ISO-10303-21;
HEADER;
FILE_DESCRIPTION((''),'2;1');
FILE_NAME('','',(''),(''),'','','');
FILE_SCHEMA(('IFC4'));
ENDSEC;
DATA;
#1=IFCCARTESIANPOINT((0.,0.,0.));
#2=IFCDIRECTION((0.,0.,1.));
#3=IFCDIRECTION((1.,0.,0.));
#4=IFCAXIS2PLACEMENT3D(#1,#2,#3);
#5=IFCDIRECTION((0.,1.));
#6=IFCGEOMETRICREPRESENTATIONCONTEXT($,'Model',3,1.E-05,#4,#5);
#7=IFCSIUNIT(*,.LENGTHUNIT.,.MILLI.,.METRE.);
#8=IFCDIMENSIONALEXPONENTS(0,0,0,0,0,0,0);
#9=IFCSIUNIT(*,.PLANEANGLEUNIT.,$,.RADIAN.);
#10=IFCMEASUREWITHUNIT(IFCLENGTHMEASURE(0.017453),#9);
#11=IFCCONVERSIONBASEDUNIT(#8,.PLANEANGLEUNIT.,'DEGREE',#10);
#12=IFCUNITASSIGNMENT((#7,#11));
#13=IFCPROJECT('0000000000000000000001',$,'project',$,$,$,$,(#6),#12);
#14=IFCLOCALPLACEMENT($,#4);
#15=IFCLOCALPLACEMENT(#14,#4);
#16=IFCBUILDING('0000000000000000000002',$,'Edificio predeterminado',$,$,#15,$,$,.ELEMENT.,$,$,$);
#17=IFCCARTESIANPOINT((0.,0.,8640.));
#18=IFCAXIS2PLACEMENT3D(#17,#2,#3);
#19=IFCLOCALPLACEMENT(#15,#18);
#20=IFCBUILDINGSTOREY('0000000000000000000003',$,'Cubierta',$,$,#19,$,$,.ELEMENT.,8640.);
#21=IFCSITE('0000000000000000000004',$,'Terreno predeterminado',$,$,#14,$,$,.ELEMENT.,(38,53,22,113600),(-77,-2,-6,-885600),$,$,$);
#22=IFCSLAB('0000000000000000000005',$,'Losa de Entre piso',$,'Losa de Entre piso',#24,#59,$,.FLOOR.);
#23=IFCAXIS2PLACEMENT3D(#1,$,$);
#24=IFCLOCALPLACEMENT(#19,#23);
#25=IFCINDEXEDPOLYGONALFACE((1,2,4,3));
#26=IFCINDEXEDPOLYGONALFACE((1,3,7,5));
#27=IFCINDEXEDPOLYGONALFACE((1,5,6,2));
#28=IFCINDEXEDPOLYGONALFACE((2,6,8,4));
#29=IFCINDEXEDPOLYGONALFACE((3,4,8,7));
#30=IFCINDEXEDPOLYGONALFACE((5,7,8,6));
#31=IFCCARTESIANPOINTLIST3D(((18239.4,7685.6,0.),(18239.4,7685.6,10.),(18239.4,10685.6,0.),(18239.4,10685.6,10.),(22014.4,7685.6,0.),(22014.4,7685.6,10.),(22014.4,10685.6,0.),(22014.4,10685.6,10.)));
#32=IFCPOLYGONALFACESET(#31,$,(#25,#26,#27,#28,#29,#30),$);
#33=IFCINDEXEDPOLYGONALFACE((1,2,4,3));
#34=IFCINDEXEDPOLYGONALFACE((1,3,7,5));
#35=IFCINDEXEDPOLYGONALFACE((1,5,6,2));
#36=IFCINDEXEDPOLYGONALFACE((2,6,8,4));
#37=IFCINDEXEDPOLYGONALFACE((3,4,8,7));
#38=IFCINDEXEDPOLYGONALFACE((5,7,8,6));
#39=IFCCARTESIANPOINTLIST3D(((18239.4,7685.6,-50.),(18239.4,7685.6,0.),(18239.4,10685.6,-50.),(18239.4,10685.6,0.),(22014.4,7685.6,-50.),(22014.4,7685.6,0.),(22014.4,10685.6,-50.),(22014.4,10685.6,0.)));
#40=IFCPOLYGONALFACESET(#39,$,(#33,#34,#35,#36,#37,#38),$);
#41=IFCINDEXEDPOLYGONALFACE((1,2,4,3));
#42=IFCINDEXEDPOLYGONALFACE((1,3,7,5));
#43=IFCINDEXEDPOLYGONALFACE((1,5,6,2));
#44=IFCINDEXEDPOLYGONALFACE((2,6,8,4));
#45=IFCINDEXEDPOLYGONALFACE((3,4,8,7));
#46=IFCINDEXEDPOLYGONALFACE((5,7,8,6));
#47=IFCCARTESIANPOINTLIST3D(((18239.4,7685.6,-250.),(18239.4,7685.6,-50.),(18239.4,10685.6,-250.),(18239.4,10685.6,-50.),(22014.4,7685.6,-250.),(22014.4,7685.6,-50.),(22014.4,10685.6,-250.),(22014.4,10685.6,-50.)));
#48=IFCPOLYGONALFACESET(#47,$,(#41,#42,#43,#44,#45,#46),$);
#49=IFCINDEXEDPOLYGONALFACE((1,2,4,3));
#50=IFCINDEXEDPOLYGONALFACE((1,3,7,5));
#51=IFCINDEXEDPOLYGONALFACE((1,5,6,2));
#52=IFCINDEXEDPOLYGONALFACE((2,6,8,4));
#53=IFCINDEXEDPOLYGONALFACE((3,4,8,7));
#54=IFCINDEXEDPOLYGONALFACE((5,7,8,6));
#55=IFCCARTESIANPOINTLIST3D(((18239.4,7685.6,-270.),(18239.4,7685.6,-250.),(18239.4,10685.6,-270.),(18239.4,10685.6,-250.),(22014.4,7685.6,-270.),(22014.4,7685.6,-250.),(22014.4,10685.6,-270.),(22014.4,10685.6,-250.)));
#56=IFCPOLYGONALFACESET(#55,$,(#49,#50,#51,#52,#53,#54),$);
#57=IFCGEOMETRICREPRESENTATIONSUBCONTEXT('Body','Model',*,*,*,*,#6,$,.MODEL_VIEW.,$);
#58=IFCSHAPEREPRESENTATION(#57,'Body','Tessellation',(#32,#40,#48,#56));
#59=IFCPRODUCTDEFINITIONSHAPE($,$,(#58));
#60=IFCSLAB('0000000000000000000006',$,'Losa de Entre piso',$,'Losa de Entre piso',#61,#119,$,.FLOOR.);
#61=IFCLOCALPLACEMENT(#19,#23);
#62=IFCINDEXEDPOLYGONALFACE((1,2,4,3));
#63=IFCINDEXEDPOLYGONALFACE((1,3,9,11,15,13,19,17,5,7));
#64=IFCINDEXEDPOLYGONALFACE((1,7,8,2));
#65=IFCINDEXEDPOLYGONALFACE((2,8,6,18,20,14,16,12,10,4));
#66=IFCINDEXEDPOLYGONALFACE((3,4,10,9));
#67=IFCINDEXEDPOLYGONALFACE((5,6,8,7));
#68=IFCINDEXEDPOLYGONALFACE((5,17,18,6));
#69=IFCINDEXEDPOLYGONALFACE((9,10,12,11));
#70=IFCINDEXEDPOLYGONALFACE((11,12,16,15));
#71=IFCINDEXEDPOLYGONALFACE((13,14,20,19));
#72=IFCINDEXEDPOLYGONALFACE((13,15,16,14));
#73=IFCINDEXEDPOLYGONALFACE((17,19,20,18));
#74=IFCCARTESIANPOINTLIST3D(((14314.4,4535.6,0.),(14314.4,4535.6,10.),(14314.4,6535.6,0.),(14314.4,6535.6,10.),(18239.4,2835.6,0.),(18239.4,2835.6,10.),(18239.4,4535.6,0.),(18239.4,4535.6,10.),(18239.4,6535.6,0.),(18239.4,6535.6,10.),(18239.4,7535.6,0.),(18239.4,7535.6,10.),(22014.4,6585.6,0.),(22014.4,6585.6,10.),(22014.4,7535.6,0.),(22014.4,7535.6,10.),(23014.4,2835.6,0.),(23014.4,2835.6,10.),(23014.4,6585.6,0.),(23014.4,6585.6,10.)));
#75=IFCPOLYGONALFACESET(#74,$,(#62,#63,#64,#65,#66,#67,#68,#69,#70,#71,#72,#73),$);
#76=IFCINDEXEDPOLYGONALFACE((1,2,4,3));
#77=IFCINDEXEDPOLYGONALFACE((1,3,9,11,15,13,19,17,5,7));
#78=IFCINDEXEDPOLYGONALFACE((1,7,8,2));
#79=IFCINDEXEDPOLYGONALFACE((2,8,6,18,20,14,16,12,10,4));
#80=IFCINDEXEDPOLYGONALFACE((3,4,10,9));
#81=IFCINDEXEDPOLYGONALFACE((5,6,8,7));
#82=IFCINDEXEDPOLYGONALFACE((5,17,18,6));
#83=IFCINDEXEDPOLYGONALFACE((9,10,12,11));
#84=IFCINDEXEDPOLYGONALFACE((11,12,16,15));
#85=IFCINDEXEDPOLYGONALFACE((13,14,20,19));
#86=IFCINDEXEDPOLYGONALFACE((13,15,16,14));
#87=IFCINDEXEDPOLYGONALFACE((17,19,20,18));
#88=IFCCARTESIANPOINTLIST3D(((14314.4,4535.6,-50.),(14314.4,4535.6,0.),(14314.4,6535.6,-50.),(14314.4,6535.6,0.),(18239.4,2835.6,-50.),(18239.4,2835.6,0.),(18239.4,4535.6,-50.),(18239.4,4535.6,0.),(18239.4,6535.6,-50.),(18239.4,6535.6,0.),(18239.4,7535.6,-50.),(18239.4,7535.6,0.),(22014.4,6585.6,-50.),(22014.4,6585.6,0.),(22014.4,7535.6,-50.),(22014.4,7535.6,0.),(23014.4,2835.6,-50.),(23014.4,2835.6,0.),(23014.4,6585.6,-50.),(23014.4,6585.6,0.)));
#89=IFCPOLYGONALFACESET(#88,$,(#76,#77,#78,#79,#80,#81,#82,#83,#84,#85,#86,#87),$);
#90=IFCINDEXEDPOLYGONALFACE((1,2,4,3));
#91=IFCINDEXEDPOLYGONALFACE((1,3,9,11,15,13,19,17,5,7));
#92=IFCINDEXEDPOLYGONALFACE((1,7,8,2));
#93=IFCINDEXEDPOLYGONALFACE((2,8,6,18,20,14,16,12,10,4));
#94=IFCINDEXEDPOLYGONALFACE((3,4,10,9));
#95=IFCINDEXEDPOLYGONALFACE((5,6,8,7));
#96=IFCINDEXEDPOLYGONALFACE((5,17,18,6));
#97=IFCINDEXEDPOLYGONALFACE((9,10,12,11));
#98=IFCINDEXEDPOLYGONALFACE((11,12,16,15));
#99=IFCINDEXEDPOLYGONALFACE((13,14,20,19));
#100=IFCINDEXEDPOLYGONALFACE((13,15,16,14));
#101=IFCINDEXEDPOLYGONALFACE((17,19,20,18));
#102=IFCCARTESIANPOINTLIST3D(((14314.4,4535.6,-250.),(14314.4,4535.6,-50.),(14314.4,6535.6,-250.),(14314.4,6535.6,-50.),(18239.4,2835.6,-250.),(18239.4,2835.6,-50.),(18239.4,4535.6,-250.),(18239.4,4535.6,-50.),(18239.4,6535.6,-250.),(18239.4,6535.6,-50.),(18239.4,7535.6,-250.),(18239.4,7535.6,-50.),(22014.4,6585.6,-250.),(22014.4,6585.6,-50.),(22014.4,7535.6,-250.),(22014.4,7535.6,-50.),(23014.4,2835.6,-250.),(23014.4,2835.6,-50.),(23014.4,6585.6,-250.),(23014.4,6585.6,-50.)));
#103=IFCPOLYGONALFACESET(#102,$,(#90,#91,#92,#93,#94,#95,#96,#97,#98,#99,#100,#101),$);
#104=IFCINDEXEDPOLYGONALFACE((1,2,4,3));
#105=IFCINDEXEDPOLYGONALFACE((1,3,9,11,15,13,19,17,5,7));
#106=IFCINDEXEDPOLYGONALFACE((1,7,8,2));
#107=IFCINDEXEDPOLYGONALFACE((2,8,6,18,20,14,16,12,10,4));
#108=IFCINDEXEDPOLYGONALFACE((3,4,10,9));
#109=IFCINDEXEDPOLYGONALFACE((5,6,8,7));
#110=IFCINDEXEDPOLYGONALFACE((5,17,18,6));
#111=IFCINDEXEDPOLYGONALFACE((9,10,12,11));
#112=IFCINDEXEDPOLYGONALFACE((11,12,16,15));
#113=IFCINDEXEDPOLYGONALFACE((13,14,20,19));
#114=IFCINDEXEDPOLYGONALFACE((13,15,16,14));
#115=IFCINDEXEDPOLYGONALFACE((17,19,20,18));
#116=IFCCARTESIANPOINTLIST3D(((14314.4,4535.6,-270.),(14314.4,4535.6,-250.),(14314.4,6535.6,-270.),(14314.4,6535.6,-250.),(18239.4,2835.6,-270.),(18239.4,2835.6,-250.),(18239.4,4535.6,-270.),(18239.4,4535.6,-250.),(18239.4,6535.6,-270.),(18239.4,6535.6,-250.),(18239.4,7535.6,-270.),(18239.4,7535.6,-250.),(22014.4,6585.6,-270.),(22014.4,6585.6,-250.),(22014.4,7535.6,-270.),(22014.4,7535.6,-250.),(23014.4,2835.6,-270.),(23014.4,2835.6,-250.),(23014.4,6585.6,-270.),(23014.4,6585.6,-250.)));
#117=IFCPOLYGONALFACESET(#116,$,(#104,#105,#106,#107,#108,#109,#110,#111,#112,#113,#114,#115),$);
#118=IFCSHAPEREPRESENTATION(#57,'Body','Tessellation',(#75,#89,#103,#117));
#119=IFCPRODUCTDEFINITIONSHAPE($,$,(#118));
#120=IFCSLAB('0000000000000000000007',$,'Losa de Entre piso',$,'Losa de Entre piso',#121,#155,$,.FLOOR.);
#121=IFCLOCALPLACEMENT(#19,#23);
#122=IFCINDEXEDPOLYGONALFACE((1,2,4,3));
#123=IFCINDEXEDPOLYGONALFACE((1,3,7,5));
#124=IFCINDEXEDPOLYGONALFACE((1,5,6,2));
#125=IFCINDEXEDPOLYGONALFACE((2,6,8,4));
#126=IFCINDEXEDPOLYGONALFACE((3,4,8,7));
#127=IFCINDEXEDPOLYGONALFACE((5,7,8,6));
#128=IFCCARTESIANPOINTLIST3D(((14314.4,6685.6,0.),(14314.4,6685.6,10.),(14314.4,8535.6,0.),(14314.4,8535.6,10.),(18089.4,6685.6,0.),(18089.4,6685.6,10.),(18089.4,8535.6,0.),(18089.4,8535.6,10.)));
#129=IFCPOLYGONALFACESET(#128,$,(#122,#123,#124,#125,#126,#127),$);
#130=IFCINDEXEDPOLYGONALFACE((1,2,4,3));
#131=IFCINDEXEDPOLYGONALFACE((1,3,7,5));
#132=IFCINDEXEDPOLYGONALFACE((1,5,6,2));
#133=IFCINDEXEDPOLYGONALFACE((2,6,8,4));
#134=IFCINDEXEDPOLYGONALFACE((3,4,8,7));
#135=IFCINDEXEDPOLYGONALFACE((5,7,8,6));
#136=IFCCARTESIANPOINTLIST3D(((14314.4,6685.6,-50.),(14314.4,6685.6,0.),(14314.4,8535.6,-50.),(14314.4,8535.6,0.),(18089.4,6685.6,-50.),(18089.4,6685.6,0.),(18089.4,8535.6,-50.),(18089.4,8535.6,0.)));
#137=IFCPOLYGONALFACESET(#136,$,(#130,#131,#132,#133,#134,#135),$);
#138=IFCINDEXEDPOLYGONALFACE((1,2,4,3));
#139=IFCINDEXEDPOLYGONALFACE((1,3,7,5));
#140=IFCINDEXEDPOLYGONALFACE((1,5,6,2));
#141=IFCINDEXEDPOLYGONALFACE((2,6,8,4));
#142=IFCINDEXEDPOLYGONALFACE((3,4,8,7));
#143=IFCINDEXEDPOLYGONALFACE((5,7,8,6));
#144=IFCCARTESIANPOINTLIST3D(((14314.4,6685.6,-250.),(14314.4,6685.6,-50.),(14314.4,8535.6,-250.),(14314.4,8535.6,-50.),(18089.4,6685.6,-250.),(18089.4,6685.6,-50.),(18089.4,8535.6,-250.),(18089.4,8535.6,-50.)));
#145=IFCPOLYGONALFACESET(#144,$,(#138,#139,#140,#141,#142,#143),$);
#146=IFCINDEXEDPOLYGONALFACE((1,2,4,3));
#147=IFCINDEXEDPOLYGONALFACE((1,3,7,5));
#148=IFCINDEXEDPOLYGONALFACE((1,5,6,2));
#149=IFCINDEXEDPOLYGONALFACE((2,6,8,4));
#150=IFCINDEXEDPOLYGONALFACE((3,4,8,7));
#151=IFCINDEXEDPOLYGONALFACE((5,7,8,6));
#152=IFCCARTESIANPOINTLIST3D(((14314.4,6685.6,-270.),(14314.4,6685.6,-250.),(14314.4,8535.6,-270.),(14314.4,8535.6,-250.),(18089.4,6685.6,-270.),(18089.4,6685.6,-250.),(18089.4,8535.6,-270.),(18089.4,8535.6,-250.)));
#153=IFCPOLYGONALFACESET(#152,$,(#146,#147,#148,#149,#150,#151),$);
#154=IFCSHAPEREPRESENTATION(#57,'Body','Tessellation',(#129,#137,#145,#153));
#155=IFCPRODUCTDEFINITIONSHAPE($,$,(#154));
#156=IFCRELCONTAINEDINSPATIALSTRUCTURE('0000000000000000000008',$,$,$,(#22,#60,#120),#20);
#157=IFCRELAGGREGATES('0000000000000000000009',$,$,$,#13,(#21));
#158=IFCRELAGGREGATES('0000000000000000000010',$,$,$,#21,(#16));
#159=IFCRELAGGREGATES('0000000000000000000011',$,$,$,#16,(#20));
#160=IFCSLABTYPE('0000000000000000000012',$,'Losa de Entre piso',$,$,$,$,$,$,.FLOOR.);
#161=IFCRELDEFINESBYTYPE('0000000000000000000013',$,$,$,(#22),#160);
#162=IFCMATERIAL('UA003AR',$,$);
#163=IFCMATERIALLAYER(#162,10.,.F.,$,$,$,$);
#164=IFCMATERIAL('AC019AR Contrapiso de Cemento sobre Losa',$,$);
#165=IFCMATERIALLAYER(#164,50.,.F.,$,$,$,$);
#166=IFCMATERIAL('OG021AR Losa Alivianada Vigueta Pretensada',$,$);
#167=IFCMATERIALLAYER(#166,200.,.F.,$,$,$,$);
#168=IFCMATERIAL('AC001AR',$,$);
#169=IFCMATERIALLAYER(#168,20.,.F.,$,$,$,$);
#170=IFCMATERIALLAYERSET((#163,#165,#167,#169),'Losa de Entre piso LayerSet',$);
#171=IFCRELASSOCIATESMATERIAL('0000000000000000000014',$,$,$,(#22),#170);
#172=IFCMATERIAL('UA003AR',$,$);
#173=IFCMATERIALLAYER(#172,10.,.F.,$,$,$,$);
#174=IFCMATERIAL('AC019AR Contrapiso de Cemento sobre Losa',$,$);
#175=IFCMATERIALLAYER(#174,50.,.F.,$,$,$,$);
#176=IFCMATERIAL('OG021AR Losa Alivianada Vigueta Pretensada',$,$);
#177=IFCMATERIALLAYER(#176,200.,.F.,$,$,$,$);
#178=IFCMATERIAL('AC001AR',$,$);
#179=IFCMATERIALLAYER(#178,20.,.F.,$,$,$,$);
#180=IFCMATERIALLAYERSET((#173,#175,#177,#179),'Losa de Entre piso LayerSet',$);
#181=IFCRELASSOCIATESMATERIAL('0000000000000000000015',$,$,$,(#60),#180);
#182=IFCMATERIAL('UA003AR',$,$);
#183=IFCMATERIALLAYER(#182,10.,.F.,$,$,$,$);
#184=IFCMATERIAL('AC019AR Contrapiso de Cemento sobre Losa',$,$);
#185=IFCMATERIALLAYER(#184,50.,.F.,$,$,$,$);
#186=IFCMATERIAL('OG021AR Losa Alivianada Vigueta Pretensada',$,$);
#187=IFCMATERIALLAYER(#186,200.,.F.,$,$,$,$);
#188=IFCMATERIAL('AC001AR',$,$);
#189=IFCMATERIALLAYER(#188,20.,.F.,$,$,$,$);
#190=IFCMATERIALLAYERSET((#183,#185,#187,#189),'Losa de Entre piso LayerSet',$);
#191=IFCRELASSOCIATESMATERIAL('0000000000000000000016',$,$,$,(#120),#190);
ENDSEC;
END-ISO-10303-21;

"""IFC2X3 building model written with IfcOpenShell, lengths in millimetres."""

from ifc_helpers import new_model, entity, si_unit, converted_unit, direction, frame, origin_with_axes, place, context, subcontext, project, spatial, polyline, outline, extrude, material, layer, layer_set, layer_usage, type_object, element, save


model = new_model("IFC2X3")

# Units and contexts
model_context = context("Model", 3, precision=1e-05, world=origin_with_axes(), true_north=direction((0.0, 1.0)))
body_context = subcontext(model_context, "Body", "Model", "MODEL_VIEW")
ifc_project = project(units=[si_unit("LENGTHUNIT", "METRE", prefix="MILLI"), converted_unit("PLANEANGLEUNIT", "DEGREE", entity("IfcLengthMeasure", 0.017453), si_unit("PLANEANGLEUNIT", "RADIAN"), dimensions=[0, 0, 0, 0, 0, 0, 0])], contexts=[model_context])

# Site, building, storey
site_placement = place(None, origin_with_axes())
site = spatial("IfcSite", under=ifc_project, at=site_placement, Name="Terreno predeterminado", CompositionType="ELEMENT", RefLatitude=(38, 53, 22, 113600), RefLongitude=(-77, -2, -6, -885600))
building_placement = place(site_placement, origin_with_axes())
building = spatial("IfcBuilding", under=site, at=building_placement, Name="Edificio predeterminado", CompositionType="ELEMENT")
storey_placement = place(building_placement, frame((0.0, 0.0, 8640.0), z_axis=(0.0, 0.0, 1.0), x_axis=(1.0, 0.0, 0.0)))
storey = spatial("IfcBuildingStorey", under=building, at=storey_placement, Name="Cubierta", CompositionType="ELEMENT", Elevation=8640.0)

# Slabs
ifc_material_1 = material(Name="UA003AR")
ifc_layer_1 = layer(ifc_material_1, 10.0, ventilated=False)
ifc_material_2 = material(Name="AC019AR Contrapiso de Cemento sobre Losa")
ifc_layer_2 = layer(ifc_material_2, 50.0, ventilated=False)
ifc_material_3 = material(Name="OG021AR Losa Alivianada Vigueta Pretensada")
ifc_layer_3 = layer(ifc_material_3, 200.0, ventilated=False)
ifc_material_4 = material(Name="AC001AR")
ifc_layer_4 = layer(ifc_material_4, 20.0, ventilated=False)
ifc_layer_set_1 = layer_set([ifc_layer_1, ifc_layer_2, ifc_layer_3, ifc_layer_4], Name="Losa de Entre piso LayerSet")
ifc_layer_usage_1 = layer_usage(ifc_layer_set_1, "AXIS3", "NEGATIVE", 0.0)
slab_type = type_object("IfcSlabType", Name="Losa de Entre piso", PredefinedType="FLOOR")
slab_1_placement = place(storey_placement, frame((0.0, 0.0, -8640.0), z_axis=(0.0, 0.0, 1.0), x_axis=(1.0, 0.0, 0.0)))
element("IfcSlab", 1, at=slab_1_placement, inside=storey, type_object=slab_type, material=ifc_layer_usage_1, Name="Losa de Entre piso", ObjectType="Losa de Entre piso", PredefinedType="FLOOR", context=body_context, shape_type="SweptSolid", body=[
    extrude(outline(polyline([(0.0, 3000.0), (3775.0, 3000.0), (3775.0, 0.0), (0.0, 0.0), (0.0, 3000.0)])), frame((22014.4, 7685.6, 8640.0), z_axis=(0.0, 0.0, -1.0), x_axis=(-1.0, 0.0, 0.0)), (0.0, 0.0, -1.0), 10.0),
    extrude(outline(polyline([(0.0, 3000.0), (3775.0, 3000.0), (3775.0, 0.0), (0.0, 0.0), (0.0, 3000.0)])), frame((22014.4, 7685.6, 8590.0), z_axis=(0.0, 0.0, -1.0), x_axis=(-1.0, 0.0, 0.0)), (0.0, 0.0, -1.0), 50.0),
    extrude(outline(polyline([(0.0, 3000.0), (3775.0, 3000.0), (3775.0, 0.0), (0.0, 0.0), (0.0, 3000.0)])), frame((22014.4, 7685.6, 8390.0), z_axis=(0.0, 0.0, -1.0), x_axis=(-1.0, 0.0, 0.0)), (0.0, 0.0, -1.0), 200.0),
    extrude(outline(polyline([(0.0, 3000.0), (3775.0, 3000.0), (3775.0, 0.0), (0.0, 0.0), (0.0, 3000.0)])), frame((22014.4, 7685.6, 8370.0), z_axis=(0.0, 0.0, -1.0), x_axis=(-1.0, 0.0, 0.0)), (0.0, 0.0, -1.0), 20.0),
])
ifc_material_5 = material(Name="UA003AR")
ifc_layer_5 = layer(ifc_material_5, 10.0, ventilated=False)
ifc_material_6 = material(Name="AC019AR Contrapiso de Cemento sobre Losa")
ifc_layer_6 = layer(ifc_material_6, 50.0, ventilated=False)
ifc_material_7 = material(Name="OG021AR Losa Alivianada Vigueta Pretensada")
ifc_layer_7 = layer(ifc_material_7, 200.0, ventilated=False)
ifc_material_8 = material(Name="AC001AR")
ifc_layer_8 = layer(ifc_material_8, 20.0, ventilated=False)
ifc_layer_set_2 = layer_set([ifc_layer_5, ifc_layer_6, ifc_layer_7, ifc_layer_8], Name="Losa de Entre piso LayerSet")
ifc_layer_usage_2 = layer_usage(ifc_layer_set_2, "AXIS3", "NEGATIVE", 0.0)
slab_2_placement = place(storey_placement, frame((0.0, 0.0, -8640.0), z_axis=(0.0, 0.0, 1.0), x_axis=(1.0, 0.0, 0.0)))
element("IfcSlab", 2, at=slab_2_placement, inside=storey, material=ifc_layer_usage_2, Name="Losa de Entre piso", ObjectType="Losa de Entre piso", PredefinedType="FLOOR", context=body_context, shape_type="SweptSolid", body=[
    extrude(outline(polyline([(0.0, 1000.0), (-3925.0, 1000.0), (-3925.0, 3000.0), (0.0, 3000.0), (0.0, 4700.0), (4775.0, 4700.0), (4775.0, 950.0), (3775.0, 950.0), (3775.0, 0.0), (0.0, 0.0), (0.0, 1000.0)])), frame((18239.4, 7535.6, 8640.0), z_axis=(0.0, 0.0, -1.0), x_axis=(1.0, 0.0, 0.0)), (0.0, 0.0, -1.0), 10.0),
    extrude(outline(polyline([(0.0, 1000.0), (-3925.0, 1000.0), (-3925.0, 3000.0), (0.0, 3000.0), (0.0, 4700.0), (4775.0, 4700.0), (4775.0, 950.0), (3775.0, 950.0), (3775.0, 0.0), (0.0, 0.0), (0.0, 1000.0)])), frame((18239.4, 7535.6, 8590.0), z_axis=(0.0, 0.0, -1.0), x_axis=(1.0, 0.0, 0.0)), (0.0, 0.0, -1.0), 50.0),
    extrude(outline(polyline([(0.0, 1000.0), (-3925.0, 1000.0), (-3925.0, 3000.0), (0.0, 3000.0), (0.0, 4700.0), (4775.0, 4700.0), (4775.0, 950.0), (3775.0, 950.0), (3775.0, 0.0), (0.0, 0.0), (0.0, 1000.0)])), frame((18239.4, 7535.6, 8390.0), z_axis=(0.0, 0.0, -1.0), x_axis=(1.0, 0.0, 0.0)), (0.0, 0.0, -1.0), 200.0),
    extrude(outline(polyline([(0.0, 1000.0), (-3925.0, 1000.0), (-3925.0, 3000.0), (0.0, 3000.0), (0.0, 4700.0), (4775.0, 4700.0), (4775.0, 950.0), (3775.0, 950.0), (3775.0, 0.0), (0.0, 0.0), (0.0, 1000.0)])), frame((18239.4, 7535.6, 8370.0), z_axis=(0.0, 0.0, -1.0), x_axis=(1.0, 0.0, 0.0)), (0.0, 0.0, -1.0), 20.0),
])
ifc_material_9 = material(Name="UA003AR")
ifc_layer_9 = layer(ifc_material_9, 10.0, ventilated=False)
ifc_material_10 = material(Name="AC019AR Contrapiso de Cemento sobre Losa")
ifc_layer_10 = layer(ifc_material_10, 50.0, ventilated=False)
ifc_material_11 = material(Name="OG021AR Losa Alivianada Vigueta Pretensada")
ifc_layer_11 = layer(ifc_material_11, 200.0, ventilated=False)
ifc_material_12 = material(Name="AC001AR")
ifc_layer_12 = layer(ifc_material_12, 20.0, ventilated=False)
ifc_layer_set_3 = layer_set([ifc_layer_9, ifc_layer_10, ifc_layer_11, ifc_layer_12], Name="Losa de Entre piso LayerSet")
ifc_layer_usage_3 = layer_usage(ifc_layer_set_3, "AXIS3", "NEGATIVE", 0.0)
slab_3_placement = place(storey_placement, frame((0.0, 0.0, -8640.0), z_axis=(0.0, 0.0, 1.0), x_axis=(1.0, 0.0, 0.0)))
element("IfcSlab", 3, at=slab_3_placement, inside=storey, material=ifc_layer_usage_3, Name="Losa de Entre piso", ObjectType="Losa de Entre piso", PredefinedType="FLOOR", context=body_context, shape_type="SweptSolid", body=[
    extrude(outline(polyline([(0.0, 1850.0), (3775.0, 1850.0), (3775.0, 0.0), (0.0, 0.0), (0.0, 1850.0)])), frame((18089.4, 6685.6, 8640.0), z_axis=(0.0, 0.0, -1.0), x_axis=(-1.0, 0.0, 0.0)), (0.0, 0.0, -1.0), 10.0),
    extrude(outline(polyline([(0.0, 1850.0), (3775.0, 1850.0), (3775.0, 0.0), (0.0, 0.0), (0.0, 1850.0)])), frame((18089.4, 6685.6, 8590.0), z_axis=(0.0, 0.0, -1.0), x_axis=(-1.0, 0.0, 0.0)), (0.0, 0.0, -1.0), 50.0),
    extrude(outline(polyline([(0.0, 1850.0), (3775.0, 1850.0), (3775.0, 0.0), (0.0, 0.0), (0.0, 1850.0)])), frame((18089.4, 6685.6, 8390.0), z_axis=(0.0, 0.0, -1.0), x_axis=(-1.0, 0.0, 0.0)), (0.0, 0.0, -1.0), 200.0),
    extrude(outline(polyline([(0.0, 1850.0), (3775.0, 1850.0), (3775.0, 0.0), (0.0, 0.0), (0.0, 1850.0)])), frame((18089.4, 6685.6, 8370.0), z_axis=(0.0, 0.0, -1.0), x_axis=(-1.0, 0.0, 0.0)), (0.0, 0.0, -1.0), 20.0),
])

save(model, "model.ifc")
